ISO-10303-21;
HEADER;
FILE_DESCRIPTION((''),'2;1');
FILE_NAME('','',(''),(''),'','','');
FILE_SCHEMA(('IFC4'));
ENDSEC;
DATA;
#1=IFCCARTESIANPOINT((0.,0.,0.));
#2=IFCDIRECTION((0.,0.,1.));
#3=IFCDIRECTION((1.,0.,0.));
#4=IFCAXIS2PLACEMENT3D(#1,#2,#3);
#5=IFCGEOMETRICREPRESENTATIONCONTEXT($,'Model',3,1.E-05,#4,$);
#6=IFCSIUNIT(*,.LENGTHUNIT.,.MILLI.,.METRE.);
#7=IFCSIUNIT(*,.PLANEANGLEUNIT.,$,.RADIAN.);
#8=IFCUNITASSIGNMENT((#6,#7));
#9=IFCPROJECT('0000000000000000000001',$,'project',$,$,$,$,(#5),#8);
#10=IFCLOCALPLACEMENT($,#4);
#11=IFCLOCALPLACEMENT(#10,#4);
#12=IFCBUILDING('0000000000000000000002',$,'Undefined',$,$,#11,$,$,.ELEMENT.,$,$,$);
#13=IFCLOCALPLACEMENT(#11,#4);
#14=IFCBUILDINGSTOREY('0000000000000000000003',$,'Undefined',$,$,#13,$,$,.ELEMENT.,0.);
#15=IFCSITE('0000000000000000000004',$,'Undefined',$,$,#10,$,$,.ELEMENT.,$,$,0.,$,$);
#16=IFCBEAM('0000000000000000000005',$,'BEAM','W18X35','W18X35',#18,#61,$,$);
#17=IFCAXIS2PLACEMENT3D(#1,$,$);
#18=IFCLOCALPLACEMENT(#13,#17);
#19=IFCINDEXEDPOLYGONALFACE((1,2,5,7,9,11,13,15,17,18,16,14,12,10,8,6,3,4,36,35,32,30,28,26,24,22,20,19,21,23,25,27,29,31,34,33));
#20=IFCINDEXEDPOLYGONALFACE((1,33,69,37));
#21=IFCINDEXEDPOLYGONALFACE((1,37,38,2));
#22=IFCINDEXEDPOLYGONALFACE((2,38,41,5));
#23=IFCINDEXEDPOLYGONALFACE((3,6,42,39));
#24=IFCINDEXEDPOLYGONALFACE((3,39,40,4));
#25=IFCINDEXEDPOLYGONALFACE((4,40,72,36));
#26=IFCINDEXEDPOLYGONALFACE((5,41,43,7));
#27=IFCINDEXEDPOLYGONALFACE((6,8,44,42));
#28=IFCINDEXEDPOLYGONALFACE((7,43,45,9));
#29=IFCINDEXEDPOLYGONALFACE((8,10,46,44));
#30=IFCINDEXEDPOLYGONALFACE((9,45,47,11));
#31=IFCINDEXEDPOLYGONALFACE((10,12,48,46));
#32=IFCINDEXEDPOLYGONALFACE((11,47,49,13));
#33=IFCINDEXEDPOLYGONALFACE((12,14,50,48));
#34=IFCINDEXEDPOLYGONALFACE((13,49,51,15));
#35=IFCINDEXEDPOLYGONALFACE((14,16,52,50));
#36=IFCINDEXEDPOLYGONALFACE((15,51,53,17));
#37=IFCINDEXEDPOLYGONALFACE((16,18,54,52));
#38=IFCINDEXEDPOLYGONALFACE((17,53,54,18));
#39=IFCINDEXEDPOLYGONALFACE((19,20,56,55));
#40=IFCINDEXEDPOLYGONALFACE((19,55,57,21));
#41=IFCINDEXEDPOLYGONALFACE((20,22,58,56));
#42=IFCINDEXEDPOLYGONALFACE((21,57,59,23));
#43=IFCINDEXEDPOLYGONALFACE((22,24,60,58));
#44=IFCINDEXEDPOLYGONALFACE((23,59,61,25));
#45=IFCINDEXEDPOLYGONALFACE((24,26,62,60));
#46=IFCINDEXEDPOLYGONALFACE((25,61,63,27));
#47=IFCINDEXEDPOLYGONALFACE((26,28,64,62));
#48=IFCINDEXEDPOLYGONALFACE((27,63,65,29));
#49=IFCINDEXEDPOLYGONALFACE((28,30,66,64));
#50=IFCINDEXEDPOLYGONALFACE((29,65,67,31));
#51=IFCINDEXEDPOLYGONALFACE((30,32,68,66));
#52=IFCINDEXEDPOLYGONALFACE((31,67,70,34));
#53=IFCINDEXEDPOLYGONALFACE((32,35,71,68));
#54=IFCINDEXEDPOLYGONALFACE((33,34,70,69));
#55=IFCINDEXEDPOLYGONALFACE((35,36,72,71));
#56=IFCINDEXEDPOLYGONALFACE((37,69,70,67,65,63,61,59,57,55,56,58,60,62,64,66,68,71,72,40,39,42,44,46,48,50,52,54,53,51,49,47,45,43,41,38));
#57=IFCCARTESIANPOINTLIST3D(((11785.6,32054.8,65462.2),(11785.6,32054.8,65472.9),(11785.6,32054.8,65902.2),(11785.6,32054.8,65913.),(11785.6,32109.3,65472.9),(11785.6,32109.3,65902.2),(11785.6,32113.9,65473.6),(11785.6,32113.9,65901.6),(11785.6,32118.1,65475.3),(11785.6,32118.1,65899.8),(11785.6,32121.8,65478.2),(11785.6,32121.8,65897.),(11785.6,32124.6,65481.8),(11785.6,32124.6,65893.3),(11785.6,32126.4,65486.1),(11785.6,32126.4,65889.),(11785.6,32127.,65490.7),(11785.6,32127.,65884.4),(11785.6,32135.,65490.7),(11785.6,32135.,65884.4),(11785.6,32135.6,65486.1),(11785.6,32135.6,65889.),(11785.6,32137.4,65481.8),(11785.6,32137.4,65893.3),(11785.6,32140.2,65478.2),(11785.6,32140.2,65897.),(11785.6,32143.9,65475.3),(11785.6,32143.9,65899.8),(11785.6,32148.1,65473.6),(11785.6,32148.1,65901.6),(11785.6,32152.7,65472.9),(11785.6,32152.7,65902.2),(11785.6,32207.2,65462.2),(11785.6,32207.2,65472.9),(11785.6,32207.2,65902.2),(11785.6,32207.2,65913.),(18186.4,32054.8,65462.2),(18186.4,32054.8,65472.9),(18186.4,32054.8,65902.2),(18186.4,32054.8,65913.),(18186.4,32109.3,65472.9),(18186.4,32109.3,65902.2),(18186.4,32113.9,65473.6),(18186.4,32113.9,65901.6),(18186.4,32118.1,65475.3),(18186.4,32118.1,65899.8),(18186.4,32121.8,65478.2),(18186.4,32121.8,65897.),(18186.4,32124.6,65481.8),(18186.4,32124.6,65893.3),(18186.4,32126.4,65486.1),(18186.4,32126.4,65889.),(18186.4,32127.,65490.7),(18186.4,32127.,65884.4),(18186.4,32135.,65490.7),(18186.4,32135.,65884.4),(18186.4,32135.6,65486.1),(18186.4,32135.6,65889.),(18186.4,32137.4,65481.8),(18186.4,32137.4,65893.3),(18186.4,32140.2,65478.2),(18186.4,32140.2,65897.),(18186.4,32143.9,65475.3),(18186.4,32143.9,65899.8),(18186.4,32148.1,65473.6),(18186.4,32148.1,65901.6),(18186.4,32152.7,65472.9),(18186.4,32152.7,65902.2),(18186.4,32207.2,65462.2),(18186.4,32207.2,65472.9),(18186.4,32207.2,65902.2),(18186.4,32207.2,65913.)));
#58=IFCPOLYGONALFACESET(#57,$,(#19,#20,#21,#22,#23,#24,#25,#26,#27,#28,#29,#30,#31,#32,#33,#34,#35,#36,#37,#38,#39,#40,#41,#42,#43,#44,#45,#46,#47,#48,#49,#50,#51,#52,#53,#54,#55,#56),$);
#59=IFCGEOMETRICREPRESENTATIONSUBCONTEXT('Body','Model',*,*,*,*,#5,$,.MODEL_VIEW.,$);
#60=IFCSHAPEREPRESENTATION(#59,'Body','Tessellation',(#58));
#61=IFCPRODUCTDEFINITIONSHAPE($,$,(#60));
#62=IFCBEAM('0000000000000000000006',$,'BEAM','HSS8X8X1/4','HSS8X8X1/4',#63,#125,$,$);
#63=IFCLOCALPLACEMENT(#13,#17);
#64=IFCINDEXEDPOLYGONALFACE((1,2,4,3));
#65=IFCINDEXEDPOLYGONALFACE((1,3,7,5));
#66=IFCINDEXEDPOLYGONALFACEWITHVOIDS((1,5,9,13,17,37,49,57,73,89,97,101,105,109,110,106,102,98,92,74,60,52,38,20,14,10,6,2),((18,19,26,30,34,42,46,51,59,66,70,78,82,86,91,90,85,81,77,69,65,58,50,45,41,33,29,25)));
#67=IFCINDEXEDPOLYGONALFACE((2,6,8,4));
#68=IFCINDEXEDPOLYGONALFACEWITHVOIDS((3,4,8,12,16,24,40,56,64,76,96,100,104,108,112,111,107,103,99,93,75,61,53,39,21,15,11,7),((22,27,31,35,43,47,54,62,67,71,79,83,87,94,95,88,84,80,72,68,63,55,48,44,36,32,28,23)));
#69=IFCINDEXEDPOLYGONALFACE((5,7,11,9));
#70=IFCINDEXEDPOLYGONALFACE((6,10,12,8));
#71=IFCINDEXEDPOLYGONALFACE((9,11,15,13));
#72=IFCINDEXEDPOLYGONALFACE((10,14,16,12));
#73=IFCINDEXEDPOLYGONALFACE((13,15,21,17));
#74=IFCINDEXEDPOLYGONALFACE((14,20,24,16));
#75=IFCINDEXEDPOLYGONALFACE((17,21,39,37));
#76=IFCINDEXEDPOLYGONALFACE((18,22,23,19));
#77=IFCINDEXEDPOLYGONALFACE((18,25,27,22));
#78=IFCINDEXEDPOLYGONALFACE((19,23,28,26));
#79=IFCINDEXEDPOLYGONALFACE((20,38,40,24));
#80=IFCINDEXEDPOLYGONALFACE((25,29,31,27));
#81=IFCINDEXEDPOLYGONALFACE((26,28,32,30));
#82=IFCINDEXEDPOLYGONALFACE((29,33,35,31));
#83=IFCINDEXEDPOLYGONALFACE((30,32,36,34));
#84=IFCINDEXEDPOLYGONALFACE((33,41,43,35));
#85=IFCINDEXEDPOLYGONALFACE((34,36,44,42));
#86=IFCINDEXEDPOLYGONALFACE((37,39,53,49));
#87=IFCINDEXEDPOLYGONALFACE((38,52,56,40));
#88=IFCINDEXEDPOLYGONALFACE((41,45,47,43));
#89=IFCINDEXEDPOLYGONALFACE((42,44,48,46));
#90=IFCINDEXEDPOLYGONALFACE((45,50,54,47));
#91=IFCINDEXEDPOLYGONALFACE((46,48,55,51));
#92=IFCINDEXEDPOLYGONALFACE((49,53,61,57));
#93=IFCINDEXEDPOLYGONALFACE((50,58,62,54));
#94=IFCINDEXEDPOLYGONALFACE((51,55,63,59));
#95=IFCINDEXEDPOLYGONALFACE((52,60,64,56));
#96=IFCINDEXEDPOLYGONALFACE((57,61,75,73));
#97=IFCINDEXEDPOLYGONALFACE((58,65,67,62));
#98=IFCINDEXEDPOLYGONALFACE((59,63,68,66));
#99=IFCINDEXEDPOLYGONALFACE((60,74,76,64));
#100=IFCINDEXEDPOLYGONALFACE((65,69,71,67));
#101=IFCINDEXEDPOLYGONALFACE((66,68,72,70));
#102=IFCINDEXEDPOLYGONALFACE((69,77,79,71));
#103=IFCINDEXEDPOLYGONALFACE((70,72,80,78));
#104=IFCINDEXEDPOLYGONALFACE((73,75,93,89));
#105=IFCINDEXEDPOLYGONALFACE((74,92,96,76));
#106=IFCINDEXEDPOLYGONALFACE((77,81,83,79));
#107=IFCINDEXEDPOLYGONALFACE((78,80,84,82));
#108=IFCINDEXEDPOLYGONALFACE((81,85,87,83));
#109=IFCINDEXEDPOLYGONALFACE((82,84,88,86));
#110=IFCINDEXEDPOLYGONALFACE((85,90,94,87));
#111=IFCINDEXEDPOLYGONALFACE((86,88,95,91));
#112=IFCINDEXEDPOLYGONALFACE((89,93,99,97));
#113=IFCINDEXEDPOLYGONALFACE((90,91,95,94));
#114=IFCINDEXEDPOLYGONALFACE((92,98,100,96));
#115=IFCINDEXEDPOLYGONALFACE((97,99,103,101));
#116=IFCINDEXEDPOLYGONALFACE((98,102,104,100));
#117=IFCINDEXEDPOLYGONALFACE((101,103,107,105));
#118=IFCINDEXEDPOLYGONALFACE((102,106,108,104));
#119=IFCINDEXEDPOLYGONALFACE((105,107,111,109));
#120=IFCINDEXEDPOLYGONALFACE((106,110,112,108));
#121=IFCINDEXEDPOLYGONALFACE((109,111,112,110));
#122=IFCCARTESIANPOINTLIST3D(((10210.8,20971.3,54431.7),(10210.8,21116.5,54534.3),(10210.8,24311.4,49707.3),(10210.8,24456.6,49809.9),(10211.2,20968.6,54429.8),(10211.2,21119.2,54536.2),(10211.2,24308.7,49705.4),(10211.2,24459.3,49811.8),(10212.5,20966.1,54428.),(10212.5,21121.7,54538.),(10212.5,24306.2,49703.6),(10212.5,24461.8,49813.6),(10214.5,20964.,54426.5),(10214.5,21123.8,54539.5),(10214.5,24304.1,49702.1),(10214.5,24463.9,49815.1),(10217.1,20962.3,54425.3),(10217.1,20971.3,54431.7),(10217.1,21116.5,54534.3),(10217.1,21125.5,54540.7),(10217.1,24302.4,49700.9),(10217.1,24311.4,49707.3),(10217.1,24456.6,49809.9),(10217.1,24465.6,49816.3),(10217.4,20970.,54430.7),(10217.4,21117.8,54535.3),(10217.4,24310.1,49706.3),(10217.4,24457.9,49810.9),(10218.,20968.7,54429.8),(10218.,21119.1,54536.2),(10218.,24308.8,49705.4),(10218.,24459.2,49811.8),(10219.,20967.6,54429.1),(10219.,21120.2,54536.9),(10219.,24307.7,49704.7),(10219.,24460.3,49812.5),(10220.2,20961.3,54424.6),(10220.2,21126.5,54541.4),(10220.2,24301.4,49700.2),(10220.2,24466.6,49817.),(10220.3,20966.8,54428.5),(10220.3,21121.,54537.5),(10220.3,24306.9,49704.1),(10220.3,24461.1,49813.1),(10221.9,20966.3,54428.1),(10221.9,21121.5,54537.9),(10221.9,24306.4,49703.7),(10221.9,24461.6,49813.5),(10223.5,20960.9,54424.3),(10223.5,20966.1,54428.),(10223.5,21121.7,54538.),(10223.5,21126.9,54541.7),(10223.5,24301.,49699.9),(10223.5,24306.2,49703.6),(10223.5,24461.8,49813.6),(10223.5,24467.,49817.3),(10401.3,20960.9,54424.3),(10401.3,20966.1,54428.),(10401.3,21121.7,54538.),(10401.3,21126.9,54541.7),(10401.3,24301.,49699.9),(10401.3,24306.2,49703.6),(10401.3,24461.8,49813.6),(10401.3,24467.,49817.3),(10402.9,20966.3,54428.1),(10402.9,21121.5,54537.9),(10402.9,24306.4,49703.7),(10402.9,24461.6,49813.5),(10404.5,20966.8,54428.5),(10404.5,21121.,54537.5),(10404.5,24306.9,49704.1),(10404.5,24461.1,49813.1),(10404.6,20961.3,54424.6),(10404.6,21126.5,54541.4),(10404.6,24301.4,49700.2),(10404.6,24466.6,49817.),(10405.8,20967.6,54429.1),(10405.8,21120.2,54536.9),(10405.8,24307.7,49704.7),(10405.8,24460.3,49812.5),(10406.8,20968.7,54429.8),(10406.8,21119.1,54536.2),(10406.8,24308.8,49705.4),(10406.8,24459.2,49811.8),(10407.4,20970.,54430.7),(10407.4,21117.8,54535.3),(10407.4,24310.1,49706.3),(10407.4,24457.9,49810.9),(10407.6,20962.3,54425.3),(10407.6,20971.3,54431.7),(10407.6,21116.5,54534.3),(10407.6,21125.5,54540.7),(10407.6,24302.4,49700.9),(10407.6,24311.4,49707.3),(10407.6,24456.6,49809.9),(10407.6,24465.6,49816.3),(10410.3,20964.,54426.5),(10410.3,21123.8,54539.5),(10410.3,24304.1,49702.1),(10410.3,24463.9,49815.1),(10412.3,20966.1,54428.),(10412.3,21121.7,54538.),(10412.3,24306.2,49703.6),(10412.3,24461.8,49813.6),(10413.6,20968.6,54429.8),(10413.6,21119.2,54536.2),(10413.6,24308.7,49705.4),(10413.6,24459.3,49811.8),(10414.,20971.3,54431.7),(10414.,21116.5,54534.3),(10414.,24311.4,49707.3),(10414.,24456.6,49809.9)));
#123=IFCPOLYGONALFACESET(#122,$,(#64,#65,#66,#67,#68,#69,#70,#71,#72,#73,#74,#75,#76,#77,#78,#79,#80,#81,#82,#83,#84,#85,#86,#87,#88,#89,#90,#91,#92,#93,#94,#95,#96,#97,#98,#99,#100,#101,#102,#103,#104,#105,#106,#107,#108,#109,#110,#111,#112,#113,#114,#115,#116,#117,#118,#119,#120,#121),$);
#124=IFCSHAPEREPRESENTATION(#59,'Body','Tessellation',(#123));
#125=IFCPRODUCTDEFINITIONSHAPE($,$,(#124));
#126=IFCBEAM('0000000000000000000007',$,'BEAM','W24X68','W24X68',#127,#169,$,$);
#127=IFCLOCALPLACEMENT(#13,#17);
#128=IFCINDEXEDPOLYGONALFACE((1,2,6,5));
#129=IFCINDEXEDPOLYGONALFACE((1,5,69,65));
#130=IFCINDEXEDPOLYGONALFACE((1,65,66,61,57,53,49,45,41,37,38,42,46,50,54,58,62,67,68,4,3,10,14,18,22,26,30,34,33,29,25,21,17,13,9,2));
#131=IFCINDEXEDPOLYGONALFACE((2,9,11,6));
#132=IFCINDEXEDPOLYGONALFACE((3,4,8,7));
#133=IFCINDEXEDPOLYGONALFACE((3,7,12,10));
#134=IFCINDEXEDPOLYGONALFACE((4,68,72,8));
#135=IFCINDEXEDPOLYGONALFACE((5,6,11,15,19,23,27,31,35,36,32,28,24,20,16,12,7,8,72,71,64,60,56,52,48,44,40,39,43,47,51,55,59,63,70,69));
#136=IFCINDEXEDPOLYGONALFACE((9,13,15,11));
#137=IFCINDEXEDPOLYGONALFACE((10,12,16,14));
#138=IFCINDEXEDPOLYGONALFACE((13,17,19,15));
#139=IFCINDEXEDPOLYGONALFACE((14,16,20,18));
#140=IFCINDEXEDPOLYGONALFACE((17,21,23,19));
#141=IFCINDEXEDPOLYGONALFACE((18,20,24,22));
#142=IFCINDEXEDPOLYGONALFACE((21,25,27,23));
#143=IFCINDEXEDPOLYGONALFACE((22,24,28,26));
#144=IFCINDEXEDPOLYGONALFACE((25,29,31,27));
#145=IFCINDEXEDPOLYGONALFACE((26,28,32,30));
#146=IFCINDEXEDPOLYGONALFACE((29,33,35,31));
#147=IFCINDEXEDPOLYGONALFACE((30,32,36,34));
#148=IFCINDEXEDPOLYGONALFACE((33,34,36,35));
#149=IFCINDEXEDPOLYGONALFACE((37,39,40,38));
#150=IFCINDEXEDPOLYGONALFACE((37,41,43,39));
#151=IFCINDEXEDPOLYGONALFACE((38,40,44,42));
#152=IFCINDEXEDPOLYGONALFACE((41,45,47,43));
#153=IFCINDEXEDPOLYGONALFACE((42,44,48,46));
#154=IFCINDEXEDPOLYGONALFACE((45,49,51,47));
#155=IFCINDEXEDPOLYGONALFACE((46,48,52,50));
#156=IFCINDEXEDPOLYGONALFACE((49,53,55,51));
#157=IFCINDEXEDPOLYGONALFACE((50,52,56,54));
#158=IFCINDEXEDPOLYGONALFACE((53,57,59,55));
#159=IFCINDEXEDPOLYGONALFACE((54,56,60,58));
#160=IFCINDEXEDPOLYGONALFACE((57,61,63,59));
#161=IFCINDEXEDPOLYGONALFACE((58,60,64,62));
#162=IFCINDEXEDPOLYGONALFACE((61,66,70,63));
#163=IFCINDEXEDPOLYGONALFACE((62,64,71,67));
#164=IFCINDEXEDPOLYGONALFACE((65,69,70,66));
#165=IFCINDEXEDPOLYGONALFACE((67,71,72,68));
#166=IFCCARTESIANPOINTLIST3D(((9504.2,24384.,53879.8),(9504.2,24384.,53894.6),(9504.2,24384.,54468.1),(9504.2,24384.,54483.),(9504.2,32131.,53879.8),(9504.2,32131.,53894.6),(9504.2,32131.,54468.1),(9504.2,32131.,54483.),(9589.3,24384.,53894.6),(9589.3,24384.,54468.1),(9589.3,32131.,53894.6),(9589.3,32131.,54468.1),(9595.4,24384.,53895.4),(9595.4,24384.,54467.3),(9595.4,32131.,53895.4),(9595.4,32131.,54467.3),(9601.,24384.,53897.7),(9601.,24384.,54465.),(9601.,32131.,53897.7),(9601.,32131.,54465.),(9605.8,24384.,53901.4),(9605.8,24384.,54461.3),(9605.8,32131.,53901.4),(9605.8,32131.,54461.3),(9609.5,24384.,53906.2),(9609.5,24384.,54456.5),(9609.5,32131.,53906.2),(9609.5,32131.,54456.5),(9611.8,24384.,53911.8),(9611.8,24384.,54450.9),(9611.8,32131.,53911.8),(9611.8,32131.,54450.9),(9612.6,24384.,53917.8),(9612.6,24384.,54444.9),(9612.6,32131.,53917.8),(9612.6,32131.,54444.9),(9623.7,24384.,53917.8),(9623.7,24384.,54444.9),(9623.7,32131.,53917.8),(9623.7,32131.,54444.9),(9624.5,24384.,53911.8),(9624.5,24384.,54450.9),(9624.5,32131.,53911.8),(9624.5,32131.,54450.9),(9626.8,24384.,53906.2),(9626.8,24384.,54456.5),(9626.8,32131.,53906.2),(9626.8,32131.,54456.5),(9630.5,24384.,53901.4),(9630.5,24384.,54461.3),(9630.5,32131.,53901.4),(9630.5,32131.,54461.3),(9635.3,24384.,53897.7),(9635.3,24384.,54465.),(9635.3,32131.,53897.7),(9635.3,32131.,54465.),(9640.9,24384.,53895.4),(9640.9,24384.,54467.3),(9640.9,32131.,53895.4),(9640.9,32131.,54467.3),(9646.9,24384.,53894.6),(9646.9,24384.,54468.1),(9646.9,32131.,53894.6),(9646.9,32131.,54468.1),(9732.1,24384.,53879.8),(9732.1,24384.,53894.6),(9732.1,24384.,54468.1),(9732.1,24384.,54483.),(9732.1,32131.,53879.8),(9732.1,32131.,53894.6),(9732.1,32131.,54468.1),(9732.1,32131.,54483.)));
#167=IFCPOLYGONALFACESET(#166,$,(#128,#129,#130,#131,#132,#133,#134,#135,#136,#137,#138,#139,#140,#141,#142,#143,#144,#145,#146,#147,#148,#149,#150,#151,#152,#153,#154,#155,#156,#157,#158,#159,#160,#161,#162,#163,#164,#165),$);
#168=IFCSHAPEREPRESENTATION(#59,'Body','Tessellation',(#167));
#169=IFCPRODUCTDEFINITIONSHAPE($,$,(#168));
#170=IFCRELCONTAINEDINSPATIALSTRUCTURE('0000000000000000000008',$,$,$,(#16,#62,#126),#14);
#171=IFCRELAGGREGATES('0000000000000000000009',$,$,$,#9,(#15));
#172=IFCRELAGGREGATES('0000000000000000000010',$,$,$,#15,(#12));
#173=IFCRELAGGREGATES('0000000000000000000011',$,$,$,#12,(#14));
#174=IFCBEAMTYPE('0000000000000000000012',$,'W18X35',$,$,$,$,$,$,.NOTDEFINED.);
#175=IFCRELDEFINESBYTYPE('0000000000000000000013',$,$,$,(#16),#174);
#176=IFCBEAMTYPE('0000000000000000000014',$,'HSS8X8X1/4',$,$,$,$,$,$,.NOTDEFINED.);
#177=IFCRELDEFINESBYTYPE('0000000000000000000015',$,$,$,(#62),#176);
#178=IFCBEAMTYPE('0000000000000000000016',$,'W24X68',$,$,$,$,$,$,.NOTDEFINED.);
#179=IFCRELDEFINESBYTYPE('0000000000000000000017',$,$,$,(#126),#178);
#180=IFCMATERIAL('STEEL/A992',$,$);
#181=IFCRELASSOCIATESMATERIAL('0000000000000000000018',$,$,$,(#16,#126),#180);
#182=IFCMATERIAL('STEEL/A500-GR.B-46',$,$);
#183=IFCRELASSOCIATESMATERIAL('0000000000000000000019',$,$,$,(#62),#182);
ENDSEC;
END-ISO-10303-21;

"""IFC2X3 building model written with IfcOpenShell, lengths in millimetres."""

from ifc_helpers import new_model, si_unit, frame, origin_with_axes, origin_2d_with_axis, place, context, subcontext, project, spatial, hollow_rectangle, i_section, extrude, material, type_object, element, save


model = new_model("IFC2X3")

# Units and contexts
model_context = context("Model", 3, precision=1e-05, world=origin_with_axes())
body_context = subcontext(model_context, "Body", "Model", "MODEL_VIEW")
ifc_project = project(units=[si_unit("LENGTHUNIT", "METRE", prefix="MILLI"), si_unit("PLANEANGLEUNIT", "RADIAN")], contexts=[model_context])

# Site, building, storey
site_placement = place(None, origin_with_axes())
site = spatial("IfcSite", under=ifc_project, at=site_placement, Name="Undefined", CompositionType="ELEMENT", RefElevation=0.0)
building_placement = place(site_placement, origin_with_axes())
building = spatial("IfcBuilding", under=site, at=building_placement, Name="Undefined", CompositionType="ELEMENT")
storey_placement = place(building_placement, origin_with_axes())
storey = spatial("IfcBuildingStorey", under=building, at=storey_placement, Name="Undefined", CompositionType="ELEMENT", Elevation=0.0)

# Shared definitions
ifc_material_1 = material(Name="STEEL/A992")

# Beams
ifc_material_2 = material(Name="STEEL/A500-GR.B-46")
beam_type_1 = type_object("IfcBeamType", Name="W18X35", PredefinedType="NOTDEFINED")
for number, where, z_axis, x_axis, name in (
    (1, (11785.6, 32131.0, 65687.6), (0.0, 0.0, 1.0), (1.0, 0.0, 0.0), "BEAM"),
):
    element("IfcBeam", number, at=place(storey_placement, frame(where, z_axis=z_axis, x_axis=x_axis)), inside=storey, type_object=beam_type_1, material=ifc_material_1, Name=name, Description="W18X35", ObjectType="W18X35", context=body_context, shape_type="SweptSolid", body=[
        extrude(i_section(OverallWidth=152.4, OverallDepth=450.9, WebThickness=7.9, FlangeThickness=10.8, FilletRadius=17.8, at=origin_2d_with_axis()), frame((6400.8, 0.0, 0.0), z_axis=(-1.0, 0.0, 0.0), x_axis=(0.0, -1.0, 0.0)), (0.0, 0.0, 1.0), 6400.8),
    ])
beam_type_2 = type_object("IfcBeamType", Name="HSS8X8X1/4", PredefinedType="NOTDEFINED")
beam_1_placement = place(storey_placement, frame((10312.4, 24384.0, 49758.6), z_axis=(0.0, 0.816542, 0.577286), x_axis=(0.0, -0.577286, 0.816542)))
element("IfcBeam", 2, at=beam_1_placement, inside=storey, type_object=beam_type_2, material=ifc_material_2, Name="BEAM", Description="HSS8X8X1/4", ObjectType="HSS8X8X1/4", context=body_context, shape_type="SweptSolid", body=[
    extrude(hollow_rectangle(XDim=203.2, YDim=203.2, WallThickness=6.3, InnerFilletRadius=6.3, OuterFilletRadius=12.7, at=origin_2d_with_axis()), frame((5785.9, 0.0, 0.0), z_axis=(-1.0, 0.0, 0.0), x_axis=(0.0, -1.0, 0.0)), (0.0, 0.0, 1.0), 5785.9),
])
beam_type_3 = type_object("IfcBeamType", Name="W24X68", PredefinedType="NOTDEFINED")
beam_2_placement = place(storey_placement, frame((9618.1, 24384.0, 54181.4), z_axis=(0.0, 0.0, 1.0), x_axis=(0.0, 1.0, 0.0)))
element("IfcBeam", 3, at=beam_2_placement, inside=storey, type_object=beam_type_3, material=ifc_material_1, Name="BEAM", Description="W24X68", ObjectType="W24X68", context=body_context, shape_type="SweptSolid", body=[
    extrude(i_section(OverallWidth=227.8, OverallDepth=603.2, WebThickness=11.1, FlangeThickness=14.9, FilletRadius=23.2, at=origin_2d_with_axis()), frame((7747.0, 0.0, 0.0), z_axis=(-1.0, 0.0, 0.0), x_axis=(0.0, -1.0, 0.0)), (0.0, 0.0, 1.0), 7747.0),
])

save(model, "model.ifc")
